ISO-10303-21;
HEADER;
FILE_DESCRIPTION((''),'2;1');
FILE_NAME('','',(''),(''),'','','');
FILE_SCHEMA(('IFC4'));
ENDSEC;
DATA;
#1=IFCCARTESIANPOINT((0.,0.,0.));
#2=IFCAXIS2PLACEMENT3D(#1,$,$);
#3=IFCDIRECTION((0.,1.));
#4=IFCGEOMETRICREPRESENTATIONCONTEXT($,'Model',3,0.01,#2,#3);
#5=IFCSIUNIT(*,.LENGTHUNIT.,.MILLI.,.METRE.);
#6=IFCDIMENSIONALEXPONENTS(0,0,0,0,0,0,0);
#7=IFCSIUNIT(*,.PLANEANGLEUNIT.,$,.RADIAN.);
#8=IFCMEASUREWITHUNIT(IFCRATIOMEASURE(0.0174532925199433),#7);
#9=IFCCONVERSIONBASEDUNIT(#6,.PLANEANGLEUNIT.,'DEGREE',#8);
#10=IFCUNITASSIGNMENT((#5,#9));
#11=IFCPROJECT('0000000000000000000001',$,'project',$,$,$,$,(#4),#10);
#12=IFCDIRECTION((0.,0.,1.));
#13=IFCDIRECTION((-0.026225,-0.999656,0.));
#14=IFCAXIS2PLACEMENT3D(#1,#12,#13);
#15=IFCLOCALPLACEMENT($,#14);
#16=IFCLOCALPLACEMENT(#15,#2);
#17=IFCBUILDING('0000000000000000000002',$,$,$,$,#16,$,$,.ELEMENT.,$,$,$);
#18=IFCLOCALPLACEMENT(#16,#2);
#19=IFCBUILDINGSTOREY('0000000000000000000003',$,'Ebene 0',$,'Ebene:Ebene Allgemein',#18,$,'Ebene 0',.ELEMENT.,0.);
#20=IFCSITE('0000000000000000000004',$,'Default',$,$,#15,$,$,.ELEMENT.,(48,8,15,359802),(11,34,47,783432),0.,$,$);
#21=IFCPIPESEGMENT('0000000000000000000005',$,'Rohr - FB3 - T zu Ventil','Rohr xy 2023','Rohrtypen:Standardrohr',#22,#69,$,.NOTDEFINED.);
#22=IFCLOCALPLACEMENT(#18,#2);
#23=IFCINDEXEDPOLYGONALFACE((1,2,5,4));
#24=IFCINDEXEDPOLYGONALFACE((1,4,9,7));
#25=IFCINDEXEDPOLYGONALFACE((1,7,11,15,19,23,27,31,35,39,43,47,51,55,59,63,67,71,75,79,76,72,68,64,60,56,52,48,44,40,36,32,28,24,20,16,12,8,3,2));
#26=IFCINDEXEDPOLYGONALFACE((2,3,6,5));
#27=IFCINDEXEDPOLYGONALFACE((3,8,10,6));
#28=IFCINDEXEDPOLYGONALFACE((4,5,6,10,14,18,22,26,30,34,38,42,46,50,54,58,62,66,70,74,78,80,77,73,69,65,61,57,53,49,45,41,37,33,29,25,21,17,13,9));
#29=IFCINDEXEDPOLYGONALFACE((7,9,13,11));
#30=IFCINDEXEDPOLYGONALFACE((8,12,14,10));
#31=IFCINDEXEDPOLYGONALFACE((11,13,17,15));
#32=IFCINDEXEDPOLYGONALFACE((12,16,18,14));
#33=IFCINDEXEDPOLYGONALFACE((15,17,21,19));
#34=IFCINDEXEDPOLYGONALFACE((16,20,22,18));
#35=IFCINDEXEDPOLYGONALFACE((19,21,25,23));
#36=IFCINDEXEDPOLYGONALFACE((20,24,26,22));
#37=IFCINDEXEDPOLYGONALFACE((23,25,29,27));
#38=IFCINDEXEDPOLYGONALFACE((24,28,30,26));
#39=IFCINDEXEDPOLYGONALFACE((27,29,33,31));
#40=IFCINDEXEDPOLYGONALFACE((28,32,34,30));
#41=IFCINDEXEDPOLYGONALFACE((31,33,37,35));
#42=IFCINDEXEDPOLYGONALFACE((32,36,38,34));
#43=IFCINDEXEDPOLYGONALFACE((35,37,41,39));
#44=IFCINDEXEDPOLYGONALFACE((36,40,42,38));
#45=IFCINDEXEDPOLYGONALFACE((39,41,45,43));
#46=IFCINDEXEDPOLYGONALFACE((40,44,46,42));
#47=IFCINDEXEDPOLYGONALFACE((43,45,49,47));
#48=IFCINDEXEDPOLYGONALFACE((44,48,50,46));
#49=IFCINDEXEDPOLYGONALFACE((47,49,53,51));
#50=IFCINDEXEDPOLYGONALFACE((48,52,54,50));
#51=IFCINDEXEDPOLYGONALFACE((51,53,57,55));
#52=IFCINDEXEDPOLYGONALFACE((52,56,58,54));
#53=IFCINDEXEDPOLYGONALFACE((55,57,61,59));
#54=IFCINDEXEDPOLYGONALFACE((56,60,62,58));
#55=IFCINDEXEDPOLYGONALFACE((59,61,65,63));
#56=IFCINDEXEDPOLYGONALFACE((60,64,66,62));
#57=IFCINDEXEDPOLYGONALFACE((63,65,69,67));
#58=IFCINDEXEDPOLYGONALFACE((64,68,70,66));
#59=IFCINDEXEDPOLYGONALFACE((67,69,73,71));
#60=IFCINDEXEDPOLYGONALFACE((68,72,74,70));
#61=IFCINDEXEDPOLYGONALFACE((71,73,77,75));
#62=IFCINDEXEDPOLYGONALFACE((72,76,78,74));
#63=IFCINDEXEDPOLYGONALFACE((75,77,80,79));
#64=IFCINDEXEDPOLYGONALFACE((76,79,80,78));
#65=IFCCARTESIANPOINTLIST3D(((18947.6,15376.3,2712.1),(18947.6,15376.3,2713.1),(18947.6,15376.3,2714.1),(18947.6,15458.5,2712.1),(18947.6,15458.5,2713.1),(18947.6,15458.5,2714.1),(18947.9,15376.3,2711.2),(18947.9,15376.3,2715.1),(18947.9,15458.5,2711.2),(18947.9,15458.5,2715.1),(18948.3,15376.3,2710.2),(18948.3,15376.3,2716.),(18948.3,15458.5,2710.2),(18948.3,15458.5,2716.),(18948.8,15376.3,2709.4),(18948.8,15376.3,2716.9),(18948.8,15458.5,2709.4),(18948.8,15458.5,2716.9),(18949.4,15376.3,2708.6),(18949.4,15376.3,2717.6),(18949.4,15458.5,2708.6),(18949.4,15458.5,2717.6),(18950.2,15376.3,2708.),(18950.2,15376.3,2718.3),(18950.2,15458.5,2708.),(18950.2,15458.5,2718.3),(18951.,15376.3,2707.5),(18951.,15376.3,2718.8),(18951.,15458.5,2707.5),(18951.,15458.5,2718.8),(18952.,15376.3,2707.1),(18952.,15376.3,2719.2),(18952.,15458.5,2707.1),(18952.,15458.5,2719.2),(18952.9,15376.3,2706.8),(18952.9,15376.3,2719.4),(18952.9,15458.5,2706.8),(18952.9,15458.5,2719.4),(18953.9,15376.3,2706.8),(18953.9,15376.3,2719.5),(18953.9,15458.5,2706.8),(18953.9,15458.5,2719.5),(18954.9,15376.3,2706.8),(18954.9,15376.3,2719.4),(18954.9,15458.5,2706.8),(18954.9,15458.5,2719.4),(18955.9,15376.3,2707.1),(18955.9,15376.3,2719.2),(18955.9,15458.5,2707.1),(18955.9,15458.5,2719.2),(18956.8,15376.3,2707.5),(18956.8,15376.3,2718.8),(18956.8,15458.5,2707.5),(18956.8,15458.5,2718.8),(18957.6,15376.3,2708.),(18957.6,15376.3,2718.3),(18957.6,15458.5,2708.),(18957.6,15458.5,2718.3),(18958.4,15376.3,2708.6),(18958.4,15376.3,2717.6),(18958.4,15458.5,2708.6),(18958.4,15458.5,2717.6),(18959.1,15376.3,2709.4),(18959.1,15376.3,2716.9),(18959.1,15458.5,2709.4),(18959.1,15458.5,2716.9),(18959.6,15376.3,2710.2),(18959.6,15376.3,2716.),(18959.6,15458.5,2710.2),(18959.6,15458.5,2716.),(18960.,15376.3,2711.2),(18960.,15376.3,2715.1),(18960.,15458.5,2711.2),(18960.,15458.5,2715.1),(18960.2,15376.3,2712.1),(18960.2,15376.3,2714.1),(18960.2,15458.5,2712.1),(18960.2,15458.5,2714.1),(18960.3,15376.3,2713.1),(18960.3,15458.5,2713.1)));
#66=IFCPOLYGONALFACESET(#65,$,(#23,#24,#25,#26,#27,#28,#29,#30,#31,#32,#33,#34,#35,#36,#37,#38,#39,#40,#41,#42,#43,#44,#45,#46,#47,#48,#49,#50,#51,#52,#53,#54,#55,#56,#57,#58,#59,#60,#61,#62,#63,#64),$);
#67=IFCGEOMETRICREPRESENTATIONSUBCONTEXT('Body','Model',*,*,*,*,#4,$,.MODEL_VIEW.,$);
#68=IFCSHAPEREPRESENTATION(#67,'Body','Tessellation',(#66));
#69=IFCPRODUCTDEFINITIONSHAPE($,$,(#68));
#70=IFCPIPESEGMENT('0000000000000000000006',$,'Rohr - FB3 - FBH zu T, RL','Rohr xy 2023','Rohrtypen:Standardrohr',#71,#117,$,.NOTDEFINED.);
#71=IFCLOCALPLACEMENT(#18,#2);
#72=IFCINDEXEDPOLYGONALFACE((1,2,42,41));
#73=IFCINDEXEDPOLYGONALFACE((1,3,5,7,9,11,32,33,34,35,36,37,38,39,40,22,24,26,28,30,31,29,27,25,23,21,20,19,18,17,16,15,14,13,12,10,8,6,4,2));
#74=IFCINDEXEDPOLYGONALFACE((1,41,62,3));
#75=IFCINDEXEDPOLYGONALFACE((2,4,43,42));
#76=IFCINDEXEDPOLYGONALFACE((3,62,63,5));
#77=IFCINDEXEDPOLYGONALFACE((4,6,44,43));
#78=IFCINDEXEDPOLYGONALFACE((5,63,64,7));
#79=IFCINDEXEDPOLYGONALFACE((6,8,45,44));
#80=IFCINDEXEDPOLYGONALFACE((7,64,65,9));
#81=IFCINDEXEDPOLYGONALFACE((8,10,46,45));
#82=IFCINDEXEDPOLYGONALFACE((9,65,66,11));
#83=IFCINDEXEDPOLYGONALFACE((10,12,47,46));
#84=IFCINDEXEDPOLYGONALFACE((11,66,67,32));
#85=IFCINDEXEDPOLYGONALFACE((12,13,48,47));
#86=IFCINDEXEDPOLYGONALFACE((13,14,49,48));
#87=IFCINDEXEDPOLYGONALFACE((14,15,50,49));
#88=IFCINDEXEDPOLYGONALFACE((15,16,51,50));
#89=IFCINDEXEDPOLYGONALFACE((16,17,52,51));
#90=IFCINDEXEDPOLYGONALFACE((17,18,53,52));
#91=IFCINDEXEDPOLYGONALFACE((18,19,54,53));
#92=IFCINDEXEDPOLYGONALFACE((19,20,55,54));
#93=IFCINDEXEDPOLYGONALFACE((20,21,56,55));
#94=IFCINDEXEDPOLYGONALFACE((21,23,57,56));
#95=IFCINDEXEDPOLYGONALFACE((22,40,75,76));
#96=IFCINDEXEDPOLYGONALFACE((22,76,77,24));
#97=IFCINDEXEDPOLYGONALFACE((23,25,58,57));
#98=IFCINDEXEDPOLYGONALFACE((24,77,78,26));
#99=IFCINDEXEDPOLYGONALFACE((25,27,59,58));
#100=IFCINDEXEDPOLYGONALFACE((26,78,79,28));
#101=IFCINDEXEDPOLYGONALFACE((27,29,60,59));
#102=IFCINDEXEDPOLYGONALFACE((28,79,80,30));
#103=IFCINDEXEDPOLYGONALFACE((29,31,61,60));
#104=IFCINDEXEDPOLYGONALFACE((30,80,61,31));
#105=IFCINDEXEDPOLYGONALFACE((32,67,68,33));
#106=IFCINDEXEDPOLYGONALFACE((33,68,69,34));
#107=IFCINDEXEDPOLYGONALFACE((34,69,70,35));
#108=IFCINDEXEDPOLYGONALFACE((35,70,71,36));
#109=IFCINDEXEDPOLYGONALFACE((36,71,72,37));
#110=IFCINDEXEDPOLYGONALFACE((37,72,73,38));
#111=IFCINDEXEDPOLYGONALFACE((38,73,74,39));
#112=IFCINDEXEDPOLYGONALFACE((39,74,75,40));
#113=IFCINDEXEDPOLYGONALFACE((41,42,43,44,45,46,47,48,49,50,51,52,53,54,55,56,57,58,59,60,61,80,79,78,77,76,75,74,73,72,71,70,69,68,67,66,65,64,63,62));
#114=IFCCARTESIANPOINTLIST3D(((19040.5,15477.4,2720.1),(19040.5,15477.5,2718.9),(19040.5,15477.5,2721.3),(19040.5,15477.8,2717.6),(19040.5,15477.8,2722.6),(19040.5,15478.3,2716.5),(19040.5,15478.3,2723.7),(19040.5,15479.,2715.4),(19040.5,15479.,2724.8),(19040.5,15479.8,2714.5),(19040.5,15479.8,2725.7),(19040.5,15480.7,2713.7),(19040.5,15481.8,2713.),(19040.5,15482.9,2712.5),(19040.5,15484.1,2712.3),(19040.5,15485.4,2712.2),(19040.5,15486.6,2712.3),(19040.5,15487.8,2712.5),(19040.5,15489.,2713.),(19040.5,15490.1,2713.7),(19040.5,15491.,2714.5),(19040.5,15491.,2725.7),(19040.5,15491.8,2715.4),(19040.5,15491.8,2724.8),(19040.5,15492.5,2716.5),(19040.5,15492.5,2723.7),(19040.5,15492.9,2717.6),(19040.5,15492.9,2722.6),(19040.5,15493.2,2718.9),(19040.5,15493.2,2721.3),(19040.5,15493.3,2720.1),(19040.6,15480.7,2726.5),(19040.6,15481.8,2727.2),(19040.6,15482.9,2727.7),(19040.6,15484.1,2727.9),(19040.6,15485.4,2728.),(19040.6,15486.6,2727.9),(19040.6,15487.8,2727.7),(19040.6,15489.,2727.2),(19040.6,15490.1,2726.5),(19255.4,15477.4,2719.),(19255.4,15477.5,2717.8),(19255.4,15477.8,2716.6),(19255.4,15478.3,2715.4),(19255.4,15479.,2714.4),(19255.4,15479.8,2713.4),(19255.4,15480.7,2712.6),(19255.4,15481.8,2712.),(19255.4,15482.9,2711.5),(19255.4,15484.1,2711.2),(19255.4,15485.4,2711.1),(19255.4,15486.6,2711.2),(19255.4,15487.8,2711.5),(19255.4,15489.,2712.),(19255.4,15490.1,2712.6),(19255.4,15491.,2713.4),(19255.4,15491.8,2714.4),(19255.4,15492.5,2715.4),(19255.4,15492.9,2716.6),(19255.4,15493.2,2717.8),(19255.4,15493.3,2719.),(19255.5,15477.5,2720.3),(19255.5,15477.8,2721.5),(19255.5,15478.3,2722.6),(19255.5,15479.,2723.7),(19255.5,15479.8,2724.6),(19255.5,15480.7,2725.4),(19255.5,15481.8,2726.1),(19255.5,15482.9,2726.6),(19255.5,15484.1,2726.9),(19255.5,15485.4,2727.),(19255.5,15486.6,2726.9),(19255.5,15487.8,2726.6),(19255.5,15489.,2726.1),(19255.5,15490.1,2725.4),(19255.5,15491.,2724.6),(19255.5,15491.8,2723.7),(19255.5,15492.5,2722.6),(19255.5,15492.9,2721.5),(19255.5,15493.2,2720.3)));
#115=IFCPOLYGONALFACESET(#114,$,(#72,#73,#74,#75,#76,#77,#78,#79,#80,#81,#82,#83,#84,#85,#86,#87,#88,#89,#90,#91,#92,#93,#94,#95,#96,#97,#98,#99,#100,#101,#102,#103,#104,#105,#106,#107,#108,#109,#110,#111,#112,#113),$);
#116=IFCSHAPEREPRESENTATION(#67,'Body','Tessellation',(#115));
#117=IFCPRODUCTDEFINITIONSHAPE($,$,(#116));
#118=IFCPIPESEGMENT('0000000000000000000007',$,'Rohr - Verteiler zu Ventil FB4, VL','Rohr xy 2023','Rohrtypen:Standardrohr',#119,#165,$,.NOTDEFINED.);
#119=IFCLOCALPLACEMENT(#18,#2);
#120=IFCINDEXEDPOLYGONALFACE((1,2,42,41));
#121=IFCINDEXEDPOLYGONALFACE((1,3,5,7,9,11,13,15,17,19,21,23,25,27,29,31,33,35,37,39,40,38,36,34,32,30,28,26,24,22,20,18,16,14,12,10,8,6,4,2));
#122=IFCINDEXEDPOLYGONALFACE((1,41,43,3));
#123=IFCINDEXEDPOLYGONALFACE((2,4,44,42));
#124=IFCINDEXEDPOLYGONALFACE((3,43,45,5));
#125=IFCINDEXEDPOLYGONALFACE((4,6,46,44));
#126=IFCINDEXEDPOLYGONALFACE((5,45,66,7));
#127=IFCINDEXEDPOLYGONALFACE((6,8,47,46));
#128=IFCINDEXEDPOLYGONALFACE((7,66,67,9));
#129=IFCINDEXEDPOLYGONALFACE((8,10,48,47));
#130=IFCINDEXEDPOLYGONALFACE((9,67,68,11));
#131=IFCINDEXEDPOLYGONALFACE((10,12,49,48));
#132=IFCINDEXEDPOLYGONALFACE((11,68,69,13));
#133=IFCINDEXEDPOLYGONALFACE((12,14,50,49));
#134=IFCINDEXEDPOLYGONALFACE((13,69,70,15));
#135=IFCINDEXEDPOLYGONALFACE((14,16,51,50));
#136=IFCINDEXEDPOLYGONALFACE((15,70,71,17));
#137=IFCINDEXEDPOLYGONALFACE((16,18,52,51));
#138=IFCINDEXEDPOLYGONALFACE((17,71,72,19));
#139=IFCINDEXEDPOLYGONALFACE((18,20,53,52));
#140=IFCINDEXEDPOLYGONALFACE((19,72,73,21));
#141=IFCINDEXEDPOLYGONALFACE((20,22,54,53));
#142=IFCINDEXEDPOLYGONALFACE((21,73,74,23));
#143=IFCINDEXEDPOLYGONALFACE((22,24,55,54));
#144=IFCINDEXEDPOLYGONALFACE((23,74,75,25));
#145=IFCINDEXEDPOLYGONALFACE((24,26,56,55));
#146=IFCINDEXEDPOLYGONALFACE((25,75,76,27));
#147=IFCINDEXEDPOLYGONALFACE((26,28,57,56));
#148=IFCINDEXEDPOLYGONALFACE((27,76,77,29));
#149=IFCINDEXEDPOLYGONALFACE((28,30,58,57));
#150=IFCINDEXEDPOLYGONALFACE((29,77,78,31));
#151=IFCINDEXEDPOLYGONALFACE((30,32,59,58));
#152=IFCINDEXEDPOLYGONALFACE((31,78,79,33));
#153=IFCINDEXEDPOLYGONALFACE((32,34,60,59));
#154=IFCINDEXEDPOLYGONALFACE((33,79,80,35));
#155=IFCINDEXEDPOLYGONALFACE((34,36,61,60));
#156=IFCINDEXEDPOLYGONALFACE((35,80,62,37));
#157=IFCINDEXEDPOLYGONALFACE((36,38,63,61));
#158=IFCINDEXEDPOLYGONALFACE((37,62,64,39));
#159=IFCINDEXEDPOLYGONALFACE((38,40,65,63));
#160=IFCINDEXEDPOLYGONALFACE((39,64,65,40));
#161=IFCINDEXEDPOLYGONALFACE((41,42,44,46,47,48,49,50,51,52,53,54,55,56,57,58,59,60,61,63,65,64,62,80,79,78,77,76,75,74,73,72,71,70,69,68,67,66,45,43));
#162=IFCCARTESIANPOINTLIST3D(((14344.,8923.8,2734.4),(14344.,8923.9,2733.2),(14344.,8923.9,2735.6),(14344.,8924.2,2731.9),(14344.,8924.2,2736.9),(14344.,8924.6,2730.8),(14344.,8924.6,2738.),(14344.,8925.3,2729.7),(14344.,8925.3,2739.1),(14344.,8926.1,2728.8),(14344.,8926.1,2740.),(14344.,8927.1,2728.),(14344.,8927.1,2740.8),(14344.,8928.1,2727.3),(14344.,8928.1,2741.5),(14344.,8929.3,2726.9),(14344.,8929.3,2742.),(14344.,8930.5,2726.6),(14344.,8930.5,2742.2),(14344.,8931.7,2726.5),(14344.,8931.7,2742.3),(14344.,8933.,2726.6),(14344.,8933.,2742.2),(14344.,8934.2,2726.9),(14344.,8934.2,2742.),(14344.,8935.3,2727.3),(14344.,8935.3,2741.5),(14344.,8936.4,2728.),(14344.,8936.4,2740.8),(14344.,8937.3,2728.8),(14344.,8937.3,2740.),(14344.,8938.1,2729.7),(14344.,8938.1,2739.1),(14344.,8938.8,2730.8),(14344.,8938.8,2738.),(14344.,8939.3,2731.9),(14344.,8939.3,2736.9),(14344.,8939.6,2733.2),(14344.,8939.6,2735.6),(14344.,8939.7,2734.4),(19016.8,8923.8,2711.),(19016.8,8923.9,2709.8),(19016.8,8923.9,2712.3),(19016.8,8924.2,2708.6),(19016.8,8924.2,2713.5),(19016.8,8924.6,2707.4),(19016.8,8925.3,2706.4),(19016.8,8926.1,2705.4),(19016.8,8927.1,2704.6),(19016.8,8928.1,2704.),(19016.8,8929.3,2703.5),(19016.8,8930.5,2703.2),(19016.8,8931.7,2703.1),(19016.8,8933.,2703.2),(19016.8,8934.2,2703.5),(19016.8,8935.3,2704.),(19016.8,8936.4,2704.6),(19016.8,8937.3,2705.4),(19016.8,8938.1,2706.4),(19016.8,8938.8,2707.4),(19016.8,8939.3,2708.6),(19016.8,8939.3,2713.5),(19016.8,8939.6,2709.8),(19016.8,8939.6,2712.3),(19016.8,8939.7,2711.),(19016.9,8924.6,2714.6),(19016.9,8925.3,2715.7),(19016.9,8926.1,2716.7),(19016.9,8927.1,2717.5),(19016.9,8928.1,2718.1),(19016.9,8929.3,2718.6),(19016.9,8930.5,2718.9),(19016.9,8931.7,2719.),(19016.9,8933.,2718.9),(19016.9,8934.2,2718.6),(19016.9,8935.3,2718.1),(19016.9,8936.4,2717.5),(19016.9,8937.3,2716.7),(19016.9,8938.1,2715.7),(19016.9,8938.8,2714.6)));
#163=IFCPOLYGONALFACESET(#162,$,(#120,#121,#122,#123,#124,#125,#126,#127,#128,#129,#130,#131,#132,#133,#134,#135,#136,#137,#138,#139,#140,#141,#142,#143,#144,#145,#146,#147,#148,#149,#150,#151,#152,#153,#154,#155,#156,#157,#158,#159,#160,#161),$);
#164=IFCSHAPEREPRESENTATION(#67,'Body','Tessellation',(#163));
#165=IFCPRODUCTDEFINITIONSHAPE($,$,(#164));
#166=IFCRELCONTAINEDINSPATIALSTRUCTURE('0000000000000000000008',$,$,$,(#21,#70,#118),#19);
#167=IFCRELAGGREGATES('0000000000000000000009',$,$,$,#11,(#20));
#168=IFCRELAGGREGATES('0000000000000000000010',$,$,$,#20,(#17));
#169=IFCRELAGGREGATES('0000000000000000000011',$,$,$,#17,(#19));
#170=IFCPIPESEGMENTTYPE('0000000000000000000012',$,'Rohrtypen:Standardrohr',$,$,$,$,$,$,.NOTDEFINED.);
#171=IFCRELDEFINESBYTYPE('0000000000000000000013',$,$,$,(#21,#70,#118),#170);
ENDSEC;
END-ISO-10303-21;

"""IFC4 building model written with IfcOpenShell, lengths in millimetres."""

from ifc_helpers import new_model, entity, si_unit, converted_unit, direction, frame, origin, place, context, subcontext, project, spatial, indexed_curve, outline, extrude, type_object, element, save


model = new_model("IFC4")

# Units and contexts
model_context = context("Model", 3, precision=0.01, world=origin(), true_north=direction((0.0, 1.0)))
body_context = subcontext(model_context, "Body", "Model", "MODEL_VIEW")
ifc_project = project(units=[si_unit("LENGTHUNIT", "METRE", prefix="MILLI"), converted_unit("PLANEANGLEUNIT", "DEGREE", entity("IfcRatioMeasure", 0.0174532925199433), si_unit("PLANEANGLEUNIT", "RADIAN"), dimensions=[0, 0, 0, 0, 0, 0, 0])], contexts=[model_context])

# Site, building, storey
site_placement = place(None, frame((0.0, 0.0, 0.0), z_axis=(0.0, 0.0, 1.0), x_axis=(-0.026225, -0.999656, 0.0)))
site = spatial("IfcSite", under=ifc_project, at=site_placement, Name="Default", CompositionType="ELEMENT", RefLatitude=(48, 8, 15, 359802), RefLongitude=(11, 34, 47, 783432), RefElevation=0.0)
building_placement = place(site_placement, origin())
building = spatial("IfcBuilding", under=site, at=building_placement, CompositionType="ELEMENT")
storey_placement = place(building_placement, origin())
storey = spatial("IfcBuildingStorey", under=building, at=storey_placement, Name="Ebene 0", ObjectType="Ebene:Ebene Allgemein", LongName="Ebene 0", CompositionType="ELEMENT", Elevation=0.0)

# Pipe segments
pipe_segment_type = type_object("IfcPipeSegmentType", Name="Rohrtypen:Standardrohr", PredefinedType="NOTDEFINED")
pipe_segment_1_placement = place(storey_placement, origin())
element("IfcPipeSegment", 1, at=pipe_segment_1_placement, inside=storey, type_object=pipe_segment_type, Name="Rohr - FB3 - T zu Ventil", Description="Rohr xy 2023", ObjectType="Rohrtypen:Standardrohr", PredefinedType="NOTDEFINED", context=body_context, shape_type="SweptSolid", body=[
    extrude(outline(indexed_curve([(6.4, 0.0), (6.3, 1.0), (6.0, 2.0), (5.7, 2.9), (5.1, 3.7), (4.5, 4.5), (3.7, 5.1), (2.9, 5.7), (2.0, 6.0), (1.0, 6.3), (0.0, 6.4), (-1.0, 6.3), (-2.0, 6.0), (-2.9, 5.7), (-3.7, 5.1), (-4.5, 4.5), (-5.1, 3.7), (-5.7, 2.9), (-6.0, 2.0), (-6.3, 1.0), (-6.4, 0.0), (-6.3, -1.0), (-6.0, -2.0), (-5.7, -2.9), (-5.1, -3.7), (-4.5, -4.5), (-3.7, -5.1), (-2.9, -5.7), (-2.0, -6.0), (-1.0, -6.3), (0.0, -6.4), (1.0, -6.3), (2.0, -6.0), (2.9, -5.7), (3.7, -5.1), (4.5, -4.5), (5.1, -3.7), (5.7, -2.9), (6.0, -2.0), (6.3, -1.0), (6.4, 0.0)], self_intersect=False)), frame((18953.9, 15376.3, 2713.1), z_axis=(0.0, 1.0, 0.0), x_axis=(-1.0, 0.0, 0.0)), (0.0, 0.0, 1.0), 82.2),
])
pipe_segment_2_placement = place(storey_placement, origin())
element("IfcPipeSegment", 2, at=pipe_segment_2_placement, inside=storey, type_object=pipe_segment_type, Name="Rohr - FB3 - FBH zu T, RL", Description="Rohr xy 2023", ObjectType="Rohrtypen:Standardrohr", PredefinedType="NOTDEFINED", context=body_context, shape_type="SweptSolid", body=[
    extrude(outline(indexed_curve([(7.9, 0.0), (7.8, 1.2), (7.6, 2.5), (7.1, 3.6), (6.4, 4.7), (5.6, 5.6), (4.7, 6.4), (3.6, 7.1), (2.5, 7.6), (1.2, 7.8), (0.0, 7.9), (-1.2, 7.8), (-2.5, 7.6), (-3.6, 7.1), (-4.7, 6.4), (-5.6, 5.6), (-6.4, 4.7), (-7.1, 3.6), (-7.6, 2.5), (-7.8, 1.2), (-7.9, 0.0), (-7.8, -1.2), (-7.6, -2.5), (-7.1, -3.6), (-6.4, -4.7), (-5.6, -5.6), (-4.7, -6.4), (-3.6, -7.1), (-2.5, -7.6), (-1.2, -7.8), (0.0, -7.9), (1.2, -7.8), (2.5, -7.6), (3.6, -7.1), (4.7, -6.4), (5.6, -5.6), (6.4, -4.7), (7.1, -3.6), (7.6, -2.5), (7.8, -1.2), (7.9, 0.0)], self_intersect=False)), frame((19255.4, 15485.4, 2719.0), z_axis=(-0.999988, 0.0, 0.005), x_axis=(0.0, 1.0, 0.0)), (0.0, 0.0, 1.0), 214.9),
])
pipe_segment_3_placement = place(storey_placement, origin())
element("IfcPipeSegment", 3, at=pipe_segment_3_placement, inside=storey, type_object=pipe_segment_type, Name="Rohr - Verteiler zu Ventil FB4, VL", Description="Rohr xy 2023", ObjectType="Rohrtypen:Standardrohr", PredefinedType="NOTDEFINED", context=body_context, shape_type="SweptSolid", body=[
    extrude(outline(indexed_curve([(7.9, 0.0), (7.8, 1.2), (7.6, 2.5), (7.1, 3.6), (6.4, 4.7), (5.6, 5.6), (4.7, 6.4), (3.6, 7.1), (2.5, 7.6), (1.2, 7.8), (0.0, 7.9), (-1.2, 7.8), (-2.5, 7.6), (-3.6, 7.1), (-4.7, 6.4), (-5.6, 5.6), (-6.4, 4.7), (-7.1, 3.6), (-7.6, 2.5), (-7.8, 1.2), (-7.9, 0.0), (-7.8, -1.2), (-7.6, -2.5), (-7.1, -3.6), (-6.4, -4.7), (-5.6, -5.6), (-4.7, -6.4), (-3.6, -7.1), (-2.5, -7.6), (-1.2, -7.8), (0.0, -7.9), (1.2, -7.8), (2.5, -7.6), (3.6, -7.1), (4.7, -6.4), (5.6, -5.6), (6.4, -4.7), (7.1, -3.6), (7.6, -2.5), (7.8, -1.2), (7.9, 0.0)], self_intersect=False)), frame((19016.8, 8931.7, 2711.0), z_axis=(-0.999988, 0.0, 0.005), x_axis=(0.0, 1.0, 0.0)), (0.0, 0.0, 1.0), 4672.9),
])

save(model, "model.ifc")
